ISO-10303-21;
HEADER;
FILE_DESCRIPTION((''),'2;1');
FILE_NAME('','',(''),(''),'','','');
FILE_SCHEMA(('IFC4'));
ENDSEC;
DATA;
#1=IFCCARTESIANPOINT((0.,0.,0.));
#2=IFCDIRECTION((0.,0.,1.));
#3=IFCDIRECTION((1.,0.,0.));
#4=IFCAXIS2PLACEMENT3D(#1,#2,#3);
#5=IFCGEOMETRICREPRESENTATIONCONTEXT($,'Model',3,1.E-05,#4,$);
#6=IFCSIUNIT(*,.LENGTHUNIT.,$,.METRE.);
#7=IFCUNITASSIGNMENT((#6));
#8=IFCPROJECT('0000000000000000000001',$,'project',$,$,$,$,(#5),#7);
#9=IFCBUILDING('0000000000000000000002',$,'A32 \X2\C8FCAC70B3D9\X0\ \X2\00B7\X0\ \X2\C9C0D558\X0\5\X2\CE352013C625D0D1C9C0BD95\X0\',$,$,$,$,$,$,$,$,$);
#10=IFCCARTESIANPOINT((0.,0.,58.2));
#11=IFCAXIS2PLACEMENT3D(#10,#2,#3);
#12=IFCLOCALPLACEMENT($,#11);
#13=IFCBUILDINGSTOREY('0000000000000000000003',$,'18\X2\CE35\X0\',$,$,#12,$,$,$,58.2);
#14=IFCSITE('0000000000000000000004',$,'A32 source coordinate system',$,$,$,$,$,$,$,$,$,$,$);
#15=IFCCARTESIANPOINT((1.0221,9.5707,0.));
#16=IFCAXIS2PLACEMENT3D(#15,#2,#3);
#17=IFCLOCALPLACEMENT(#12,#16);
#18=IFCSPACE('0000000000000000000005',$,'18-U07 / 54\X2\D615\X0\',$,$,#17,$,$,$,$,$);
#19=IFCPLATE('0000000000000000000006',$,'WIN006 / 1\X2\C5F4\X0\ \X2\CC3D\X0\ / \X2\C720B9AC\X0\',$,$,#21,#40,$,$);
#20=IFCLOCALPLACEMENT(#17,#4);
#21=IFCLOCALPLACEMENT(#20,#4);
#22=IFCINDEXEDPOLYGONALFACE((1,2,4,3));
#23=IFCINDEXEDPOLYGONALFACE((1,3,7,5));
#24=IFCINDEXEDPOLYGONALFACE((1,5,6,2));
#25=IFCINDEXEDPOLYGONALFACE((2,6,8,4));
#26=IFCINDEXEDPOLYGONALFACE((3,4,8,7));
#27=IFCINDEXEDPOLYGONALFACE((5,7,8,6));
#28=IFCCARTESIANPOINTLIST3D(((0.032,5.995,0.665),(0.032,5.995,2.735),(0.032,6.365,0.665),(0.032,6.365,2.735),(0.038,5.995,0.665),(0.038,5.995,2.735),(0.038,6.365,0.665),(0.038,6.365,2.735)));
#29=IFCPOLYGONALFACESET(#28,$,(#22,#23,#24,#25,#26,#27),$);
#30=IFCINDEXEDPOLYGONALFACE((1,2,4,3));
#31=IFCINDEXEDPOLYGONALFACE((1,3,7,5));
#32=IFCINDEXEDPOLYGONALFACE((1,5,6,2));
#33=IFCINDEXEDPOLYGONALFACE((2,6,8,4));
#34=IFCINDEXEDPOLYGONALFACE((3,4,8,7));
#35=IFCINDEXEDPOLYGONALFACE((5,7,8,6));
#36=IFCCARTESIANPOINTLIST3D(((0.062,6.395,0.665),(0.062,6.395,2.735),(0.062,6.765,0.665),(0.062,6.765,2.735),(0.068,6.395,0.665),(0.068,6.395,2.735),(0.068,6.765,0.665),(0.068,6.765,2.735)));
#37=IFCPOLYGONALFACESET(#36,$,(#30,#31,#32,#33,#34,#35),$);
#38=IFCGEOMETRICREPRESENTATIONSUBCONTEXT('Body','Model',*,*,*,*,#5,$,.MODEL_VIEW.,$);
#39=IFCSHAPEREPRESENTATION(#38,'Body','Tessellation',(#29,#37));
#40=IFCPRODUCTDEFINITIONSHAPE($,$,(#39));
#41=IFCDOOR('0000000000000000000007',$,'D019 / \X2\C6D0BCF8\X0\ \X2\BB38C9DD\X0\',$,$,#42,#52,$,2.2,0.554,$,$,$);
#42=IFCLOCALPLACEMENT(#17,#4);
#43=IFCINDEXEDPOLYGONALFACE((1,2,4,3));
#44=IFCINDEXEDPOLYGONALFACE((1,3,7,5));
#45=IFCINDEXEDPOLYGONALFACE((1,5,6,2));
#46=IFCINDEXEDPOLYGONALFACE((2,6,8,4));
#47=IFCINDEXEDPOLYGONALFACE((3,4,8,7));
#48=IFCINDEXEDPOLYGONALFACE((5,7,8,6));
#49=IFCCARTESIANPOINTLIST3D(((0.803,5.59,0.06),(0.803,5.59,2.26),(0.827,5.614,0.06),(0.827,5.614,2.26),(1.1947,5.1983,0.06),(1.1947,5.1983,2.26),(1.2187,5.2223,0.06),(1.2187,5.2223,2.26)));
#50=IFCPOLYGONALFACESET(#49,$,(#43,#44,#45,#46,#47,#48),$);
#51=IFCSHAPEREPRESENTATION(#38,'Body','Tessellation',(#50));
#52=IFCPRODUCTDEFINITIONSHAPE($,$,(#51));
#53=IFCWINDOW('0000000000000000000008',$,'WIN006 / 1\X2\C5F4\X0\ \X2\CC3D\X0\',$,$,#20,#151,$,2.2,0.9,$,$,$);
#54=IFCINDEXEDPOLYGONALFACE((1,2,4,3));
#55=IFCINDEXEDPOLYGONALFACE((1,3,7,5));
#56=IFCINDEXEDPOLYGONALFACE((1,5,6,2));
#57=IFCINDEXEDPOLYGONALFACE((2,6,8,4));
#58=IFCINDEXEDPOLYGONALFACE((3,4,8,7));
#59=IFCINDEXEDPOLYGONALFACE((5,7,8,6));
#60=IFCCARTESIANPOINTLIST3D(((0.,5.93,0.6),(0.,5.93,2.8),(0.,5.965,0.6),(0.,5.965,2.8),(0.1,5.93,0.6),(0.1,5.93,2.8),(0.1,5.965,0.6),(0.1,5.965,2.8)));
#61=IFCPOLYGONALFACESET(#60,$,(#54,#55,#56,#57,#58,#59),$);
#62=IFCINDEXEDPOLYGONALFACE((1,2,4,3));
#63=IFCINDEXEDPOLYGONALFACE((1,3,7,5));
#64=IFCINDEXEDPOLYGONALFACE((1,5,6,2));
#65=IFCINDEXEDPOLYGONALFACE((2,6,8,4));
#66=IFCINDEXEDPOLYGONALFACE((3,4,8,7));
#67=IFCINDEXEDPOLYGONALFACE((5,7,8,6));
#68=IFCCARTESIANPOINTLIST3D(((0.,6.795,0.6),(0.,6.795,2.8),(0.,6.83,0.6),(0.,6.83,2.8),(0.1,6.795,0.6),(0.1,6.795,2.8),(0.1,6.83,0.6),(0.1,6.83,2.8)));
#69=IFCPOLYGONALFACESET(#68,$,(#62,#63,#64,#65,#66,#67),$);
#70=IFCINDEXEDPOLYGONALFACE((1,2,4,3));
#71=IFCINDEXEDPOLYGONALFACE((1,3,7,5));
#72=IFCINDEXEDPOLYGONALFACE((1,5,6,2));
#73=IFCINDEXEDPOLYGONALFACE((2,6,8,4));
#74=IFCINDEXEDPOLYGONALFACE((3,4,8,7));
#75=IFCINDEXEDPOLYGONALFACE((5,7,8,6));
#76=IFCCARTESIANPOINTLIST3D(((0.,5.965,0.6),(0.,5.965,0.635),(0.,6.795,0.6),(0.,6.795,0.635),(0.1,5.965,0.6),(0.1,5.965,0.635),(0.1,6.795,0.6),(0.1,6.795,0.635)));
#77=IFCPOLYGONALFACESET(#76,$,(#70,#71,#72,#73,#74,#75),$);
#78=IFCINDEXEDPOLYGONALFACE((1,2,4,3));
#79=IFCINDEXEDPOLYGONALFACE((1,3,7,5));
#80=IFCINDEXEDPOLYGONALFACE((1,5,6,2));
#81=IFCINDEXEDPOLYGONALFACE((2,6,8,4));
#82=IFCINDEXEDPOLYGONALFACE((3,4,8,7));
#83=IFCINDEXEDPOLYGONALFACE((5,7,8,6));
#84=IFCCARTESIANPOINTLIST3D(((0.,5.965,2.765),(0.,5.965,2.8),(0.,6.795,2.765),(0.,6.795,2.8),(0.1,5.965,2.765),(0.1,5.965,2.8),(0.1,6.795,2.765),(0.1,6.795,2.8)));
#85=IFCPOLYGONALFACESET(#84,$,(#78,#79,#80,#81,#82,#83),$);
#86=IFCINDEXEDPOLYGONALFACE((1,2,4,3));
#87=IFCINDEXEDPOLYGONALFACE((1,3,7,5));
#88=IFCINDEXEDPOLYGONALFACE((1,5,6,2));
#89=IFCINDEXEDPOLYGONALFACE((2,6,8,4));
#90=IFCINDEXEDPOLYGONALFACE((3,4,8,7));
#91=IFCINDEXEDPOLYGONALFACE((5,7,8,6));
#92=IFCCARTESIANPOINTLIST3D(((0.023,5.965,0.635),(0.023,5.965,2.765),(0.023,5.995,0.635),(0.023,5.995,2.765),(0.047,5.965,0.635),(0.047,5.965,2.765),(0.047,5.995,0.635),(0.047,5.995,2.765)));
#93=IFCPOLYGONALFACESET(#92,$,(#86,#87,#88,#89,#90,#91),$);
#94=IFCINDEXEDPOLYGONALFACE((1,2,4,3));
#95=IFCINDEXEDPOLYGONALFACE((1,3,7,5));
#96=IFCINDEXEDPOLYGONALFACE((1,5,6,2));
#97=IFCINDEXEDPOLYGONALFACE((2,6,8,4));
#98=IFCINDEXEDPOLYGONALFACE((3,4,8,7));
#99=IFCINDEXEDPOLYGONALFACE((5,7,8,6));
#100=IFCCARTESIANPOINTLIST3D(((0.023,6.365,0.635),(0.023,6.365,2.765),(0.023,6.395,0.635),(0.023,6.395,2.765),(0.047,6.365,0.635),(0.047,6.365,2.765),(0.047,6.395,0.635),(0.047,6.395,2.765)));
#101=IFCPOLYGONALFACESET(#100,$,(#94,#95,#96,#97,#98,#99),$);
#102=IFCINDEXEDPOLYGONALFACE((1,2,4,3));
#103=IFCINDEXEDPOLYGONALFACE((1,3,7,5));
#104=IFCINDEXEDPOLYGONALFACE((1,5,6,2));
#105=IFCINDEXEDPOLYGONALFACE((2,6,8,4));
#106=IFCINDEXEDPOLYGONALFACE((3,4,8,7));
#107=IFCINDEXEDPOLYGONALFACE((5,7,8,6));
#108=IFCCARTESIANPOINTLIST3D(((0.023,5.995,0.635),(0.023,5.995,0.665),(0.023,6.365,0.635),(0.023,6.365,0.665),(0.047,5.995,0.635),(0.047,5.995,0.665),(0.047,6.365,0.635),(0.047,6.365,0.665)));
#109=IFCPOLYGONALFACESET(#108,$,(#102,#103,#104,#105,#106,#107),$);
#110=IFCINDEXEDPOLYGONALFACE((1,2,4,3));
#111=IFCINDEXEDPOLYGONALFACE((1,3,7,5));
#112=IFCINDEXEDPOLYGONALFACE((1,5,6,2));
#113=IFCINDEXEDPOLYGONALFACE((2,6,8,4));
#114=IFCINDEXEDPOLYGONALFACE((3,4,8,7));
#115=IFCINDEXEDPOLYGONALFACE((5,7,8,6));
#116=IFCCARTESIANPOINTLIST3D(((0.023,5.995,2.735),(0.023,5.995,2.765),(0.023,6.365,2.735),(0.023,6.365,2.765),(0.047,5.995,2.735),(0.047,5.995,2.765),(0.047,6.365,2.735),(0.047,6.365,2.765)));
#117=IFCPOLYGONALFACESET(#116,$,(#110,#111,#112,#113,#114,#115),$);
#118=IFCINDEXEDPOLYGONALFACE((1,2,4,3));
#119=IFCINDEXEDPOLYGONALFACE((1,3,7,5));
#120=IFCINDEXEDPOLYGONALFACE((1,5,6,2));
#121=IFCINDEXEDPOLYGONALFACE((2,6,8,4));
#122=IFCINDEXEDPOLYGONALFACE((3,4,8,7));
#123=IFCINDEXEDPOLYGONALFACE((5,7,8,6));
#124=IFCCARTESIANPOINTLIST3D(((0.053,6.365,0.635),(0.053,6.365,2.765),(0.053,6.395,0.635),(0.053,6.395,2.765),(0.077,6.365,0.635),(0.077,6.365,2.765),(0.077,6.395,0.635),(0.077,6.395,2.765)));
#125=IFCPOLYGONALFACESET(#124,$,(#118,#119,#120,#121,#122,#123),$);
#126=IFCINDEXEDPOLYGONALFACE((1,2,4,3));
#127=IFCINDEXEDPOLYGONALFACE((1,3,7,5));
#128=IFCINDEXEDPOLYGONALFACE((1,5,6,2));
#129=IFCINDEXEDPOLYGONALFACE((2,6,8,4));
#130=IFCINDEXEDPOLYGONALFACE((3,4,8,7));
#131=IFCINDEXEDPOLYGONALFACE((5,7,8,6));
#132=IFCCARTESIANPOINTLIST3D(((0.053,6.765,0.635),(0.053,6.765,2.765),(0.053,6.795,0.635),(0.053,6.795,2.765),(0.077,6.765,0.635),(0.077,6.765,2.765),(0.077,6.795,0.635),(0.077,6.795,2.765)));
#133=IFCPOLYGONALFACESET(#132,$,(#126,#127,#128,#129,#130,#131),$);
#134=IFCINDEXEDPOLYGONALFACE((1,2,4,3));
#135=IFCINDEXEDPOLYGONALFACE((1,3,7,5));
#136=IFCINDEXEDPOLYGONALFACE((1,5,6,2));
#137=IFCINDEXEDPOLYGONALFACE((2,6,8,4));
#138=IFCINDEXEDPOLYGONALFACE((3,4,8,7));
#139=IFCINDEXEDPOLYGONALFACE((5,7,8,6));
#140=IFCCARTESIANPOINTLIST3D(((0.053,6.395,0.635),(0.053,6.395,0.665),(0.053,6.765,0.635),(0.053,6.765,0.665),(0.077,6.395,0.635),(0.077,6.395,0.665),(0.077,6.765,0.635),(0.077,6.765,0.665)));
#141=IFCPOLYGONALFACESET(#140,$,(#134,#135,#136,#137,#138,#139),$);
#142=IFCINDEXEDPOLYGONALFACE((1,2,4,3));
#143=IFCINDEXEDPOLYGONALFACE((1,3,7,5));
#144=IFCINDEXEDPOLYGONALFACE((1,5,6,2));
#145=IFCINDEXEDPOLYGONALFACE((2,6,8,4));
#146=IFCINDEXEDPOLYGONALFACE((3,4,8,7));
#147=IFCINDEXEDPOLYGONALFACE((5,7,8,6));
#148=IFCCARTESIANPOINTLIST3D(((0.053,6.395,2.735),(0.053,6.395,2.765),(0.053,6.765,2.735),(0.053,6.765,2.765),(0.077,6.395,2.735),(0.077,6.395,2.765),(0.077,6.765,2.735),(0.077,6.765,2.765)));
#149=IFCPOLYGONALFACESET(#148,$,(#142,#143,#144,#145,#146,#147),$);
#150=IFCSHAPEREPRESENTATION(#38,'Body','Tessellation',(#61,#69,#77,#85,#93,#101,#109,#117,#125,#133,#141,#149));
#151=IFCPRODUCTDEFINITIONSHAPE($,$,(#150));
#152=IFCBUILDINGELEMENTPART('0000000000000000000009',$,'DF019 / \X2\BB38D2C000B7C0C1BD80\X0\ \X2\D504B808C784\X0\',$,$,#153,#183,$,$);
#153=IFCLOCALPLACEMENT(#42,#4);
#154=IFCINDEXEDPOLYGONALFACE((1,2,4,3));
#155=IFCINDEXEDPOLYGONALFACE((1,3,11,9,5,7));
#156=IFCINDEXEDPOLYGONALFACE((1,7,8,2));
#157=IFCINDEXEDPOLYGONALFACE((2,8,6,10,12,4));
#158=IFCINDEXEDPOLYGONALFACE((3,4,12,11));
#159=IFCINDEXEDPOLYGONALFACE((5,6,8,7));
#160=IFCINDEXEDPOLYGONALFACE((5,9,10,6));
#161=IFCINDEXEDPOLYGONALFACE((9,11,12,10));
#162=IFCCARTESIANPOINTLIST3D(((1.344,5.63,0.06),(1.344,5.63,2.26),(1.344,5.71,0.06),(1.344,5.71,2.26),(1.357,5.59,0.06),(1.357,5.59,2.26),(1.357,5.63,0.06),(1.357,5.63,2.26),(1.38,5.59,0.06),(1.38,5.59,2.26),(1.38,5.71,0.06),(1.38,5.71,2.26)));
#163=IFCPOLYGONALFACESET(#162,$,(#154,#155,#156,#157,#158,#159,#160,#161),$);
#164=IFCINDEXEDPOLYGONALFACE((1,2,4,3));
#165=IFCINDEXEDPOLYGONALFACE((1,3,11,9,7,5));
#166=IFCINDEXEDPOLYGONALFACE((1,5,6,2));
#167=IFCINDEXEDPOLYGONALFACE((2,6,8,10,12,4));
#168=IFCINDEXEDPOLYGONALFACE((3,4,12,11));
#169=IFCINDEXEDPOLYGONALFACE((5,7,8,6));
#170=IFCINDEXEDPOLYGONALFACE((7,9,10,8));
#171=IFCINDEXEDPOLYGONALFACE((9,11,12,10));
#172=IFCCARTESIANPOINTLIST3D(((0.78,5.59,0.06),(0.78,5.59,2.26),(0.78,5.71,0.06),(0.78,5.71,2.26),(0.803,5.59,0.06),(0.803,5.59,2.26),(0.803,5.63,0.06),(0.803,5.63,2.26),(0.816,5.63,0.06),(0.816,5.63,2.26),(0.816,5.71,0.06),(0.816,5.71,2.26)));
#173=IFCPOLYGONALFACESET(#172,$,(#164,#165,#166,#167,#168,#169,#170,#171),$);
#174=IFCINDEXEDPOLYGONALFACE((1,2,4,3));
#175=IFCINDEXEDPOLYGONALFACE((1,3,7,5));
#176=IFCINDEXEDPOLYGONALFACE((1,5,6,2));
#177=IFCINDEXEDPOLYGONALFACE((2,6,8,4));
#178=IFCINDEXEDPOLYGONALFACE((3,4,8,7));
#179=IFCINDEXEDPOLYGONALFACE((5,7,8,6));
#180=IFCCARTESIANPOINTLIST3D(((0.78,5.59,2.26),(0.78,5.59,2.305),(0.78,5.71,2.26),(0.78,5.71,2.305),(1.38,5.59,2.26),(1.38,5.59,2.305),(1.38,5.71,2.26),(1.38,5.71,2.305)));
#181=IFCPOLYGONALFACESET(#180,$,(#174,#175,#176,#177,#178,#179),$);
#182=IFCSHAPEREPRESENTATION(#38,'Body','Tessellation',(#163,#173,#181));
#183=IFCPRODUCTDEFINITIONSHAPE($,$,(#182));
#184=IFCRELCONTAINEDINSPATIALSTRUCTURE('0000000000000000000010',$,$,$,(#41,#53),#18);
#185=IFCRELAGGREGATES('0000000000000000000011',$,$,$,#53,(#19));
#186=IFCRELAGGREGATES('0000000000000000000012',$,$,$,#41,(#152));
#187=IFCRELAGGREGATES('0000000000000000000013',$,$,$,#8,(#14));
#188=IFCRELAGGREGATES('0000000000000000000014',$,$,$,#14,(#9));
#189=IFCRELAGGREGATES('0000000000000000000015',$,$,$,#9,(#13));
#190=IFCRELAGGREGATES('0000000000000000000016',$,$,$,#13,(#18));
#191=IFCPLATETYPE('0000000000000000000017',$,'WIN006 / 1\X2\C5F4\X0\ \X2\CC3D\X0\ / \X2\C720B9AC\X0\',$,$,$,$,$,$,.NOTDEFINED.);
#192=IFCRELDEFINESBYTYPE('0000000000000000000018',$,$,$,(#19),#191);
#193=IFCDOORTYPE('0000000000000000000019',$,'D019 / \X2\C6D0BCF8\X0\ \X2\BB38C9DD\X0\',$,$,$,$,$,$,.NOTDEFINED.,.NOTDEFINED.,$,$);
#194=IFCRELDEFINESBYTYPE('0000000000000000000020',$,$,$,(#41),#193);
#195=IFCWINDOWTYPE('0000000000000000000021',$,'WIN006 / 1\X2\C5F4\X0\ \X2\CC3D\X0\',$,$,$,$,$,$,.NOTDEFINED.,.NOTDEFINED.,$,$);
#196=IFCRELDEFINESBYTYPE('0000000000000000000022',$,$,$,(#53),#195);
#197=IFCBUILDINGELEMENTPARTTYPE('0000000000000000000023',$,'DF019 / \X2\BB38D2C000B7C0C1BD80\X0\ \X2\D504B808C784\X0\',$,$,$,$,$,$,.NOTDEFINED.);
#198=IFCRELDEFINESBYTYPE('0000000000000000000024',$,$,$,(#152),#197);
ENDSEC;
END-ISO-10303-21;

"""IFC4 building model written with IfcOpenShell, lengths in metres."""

from ifc_helpers import new_model, si_unit, frame, origin, origin_with_axes, place, context, subcontext, project, spatial, polyline, outline, extrude, source, transform, mapped, type_object, type_shapes, element, aggregate, save


model = new_model("IFC4")

# Units and contexts
model_context = context("Model", 3, precision=1e-05, world=origin_with_axes())
body_context = subcontext(model_context, "Body", "Model", "MODEL_VIEW")
ifc_project = project(units=[si_unit("LENGTHUNIT", "METRE")], contexts=[model_context])

# Plate
storey_placement = place(None, frame((0.0, 0.0, 58.2), z_axis=(0.0, 0.0, 1.0), x_axis=(1.0, 0.0, 0.0)))
space_placement = place(storey_placement, frame((1.0221, 9.5707, 0.0), z_axis=(0.0, 0.0, 1.0), x_axis=(1.0, 0.0, 0.0)))
plate_type_1 = type_object("IfcPlateType", Name="WIN006 / 1열 창 / 유리", PredefinedType="NOTDEFINED")
shared_shape_1 = source(origin(), body_context, "Body", "SweptSolid", [
    extrude(outline(polyline([(0.032, 5.995), (0.032, 6.365), (0.038, 6.365), (0.038, 5.995), (0.032, 5.995)])), frame((0.0, 0.0, 0.665)), (0.0, 0.0, 1.0), 2.07),
    extrude(outline(polyline([(0.062, 6.395), (0.062, 6.765), (0.068, 6.765), (0.068, 6.395), (0.062, 6.395)])), frame((0.0, 0.0, 0.665)), (0.0, 0.0, 1.0), 2.07),
])
type_shapes(plate_type_1, [shared_shape_1])
window_1_placement = place(space_placement, origin_with_axes())
plate_1_placement = place(window_1_placement, origin_with_axes())
plate_1 = element("IfcPlate", 1, at=plate_1_placement, type_object=plate_type_1, Name="WIN006 / 1열 창 / 유리", context=body_context, shape_type="MappedRepresentation", body=[
    mapped(shared_shape_1, transform((0.0, 0.0, 0.0), scale=1.0)),
])

# Site, building, storey, space
site = spatial("IfcSite", under=ifc_project, Name="A32 source coordinate system")
building = spatial("IfcBuilding", under=site, Name="A32 주거동 · 지하5층–옥탑지붕")
storey = spatial("IfcBuildingStorey", under=building, at=storey_placement, Name="18층", Elevation=58.2)
space = spatial("IfcSpace", under=storey, at=space_placement, Name="18-U07 / 54형")

# Door
door_type_1 = type_object("IfcDoorType", Name="D019 / 원본 문짝", OperationType="NOTDEFINED", PredefinedType="NOTDEFINED")
shared_shape_2 = source(origin(), body_context, "Body", "SweptSolid", [
    extrude(outline(polyline([(1.2187, 5.2223), (1.1947, 5.1983), (0.803, 5.59), (0.827, 5.614), (1.2187, 5.2223)])), frame((0.0, 0.0, 0.06)), (0.0, 0.0, 1.0), 2.2),
])
type_shapes(door_type_1, [shared_shape_2])
door_1_placement = place(space_placement, origin_with_axes())
door_1 = element("IfcDoor", 2, at=door_1_placement, inside=space, type_object=door_type_1, Name="D019 / 원본 문짝", OverallHeight=2.2, OverallWidth=0.554, context=body_context, shape_type="MappedRepresentation", body=[
    mapped(shared_shape_2, transform((0.0, 0.0, 0.0), scale=1.0)),
])

# Window
window_type_1 = type_object("IfcWindowType", Name="WIN006 / 1열 창", PartitioningType="NOTDEFINED", PredefinedType="NOTDEFINED")
shared_shape_3 = source(origin(), body_context, "Body", "SweptSolid", [
    extrude(outline(polyline([(0.0, 5.93), (0.0, 5.965), (0.1, 5.965), (0.1, 5.93), (0.0, 5.93)])), frame((0.0, 0.0, 0.6)), (0.0, 0.0, 1.0), 2.2),
    extrude(outline(polyline([(0.0, 6.795), (0.0, 6.83), (0.1, 6.83), (0.1, 6.795), (0.0, 6.795)])), frame((0.0, 0.0, 0.6)), (0.0, 0.0, 1.0), 2.2),
    extrude(outline(polyline([(0.0, 5.965), (0.0, 6.795), (0.1, 6.795), (0.1, 5.965), (0.0, 5.965)])), frame((0.0, 0.0, 0.6)), (0.0, 0.0, 1.0), 0.035),
    extrude(outline(polyline([(0.0, 5.965), (0.0, 6.795), (0.1, 6.795), (0.1, 5.965), (0.0, 5.965)])), frame((0.0, 0.0, 2.765)), (0.0, 0.0, 1.0), 0.035),
    extrude(outline(polyline([(0.023, 5.965), (0.023, 5.995), (0.047, 5.995), (0.047, 5.965), (0.023, 5.965)])), frame((0.0, 0.0, 0.635)), (0.0, 0.0, 1.0), 2.13),
    extrude(outline(polyline([(0.023, 6.365), (0.023, 6.395), (0.047, 6.395), (0.047, 6.365), (0.023, 6.365)])), frame((0.0, 0.0, 0.635)), (0.0, 0.0, 1.0), 2.13),
    extrude(outline(polyline([(0.023, 5.995), (0.023, 6.365), (0.047, 6.365), (0.047, 5.995), (0.023, 5.995)])), frame((0.0, 0.0, 0.635)), (0.0, 0.0, 1.0), 0.03),
    extrude(outline(polyline([(0.023, 5.995), (0.023, 6.365), (0.047, 6.365), (0.047, 5.995), (0.023, 5.995)])), frame((0.0, 0.0, 2.735)), (0.0, 0.0, 1.0), 0.03),
    extrude(outline(polyline([(0.053, 6.365), (0.053, 6.395), (0.077, 6.395), (0.077, 6.365), (0.053, 6.365)])), frame((0.0, 0.0, 0.635)), (0.0, 0.0, 1.0), 2.13),
    extrude(outline(polyline([(0.053, 6.765), (0.053, 6.795), (0.077, 6.795), (0.077, 6.765), (0.053, 6.765)])), frame((0.0, 0.0, 0.635)), (0.0, 0.0, 1.0), 2.13),
    extrude(outline(polyline([(0.053, 6.395), (0.053, 6.765), (0.077, 6.765), (0.077, 6.395), (0.053, 6.395)])), frame((0.0, 0.0, 0.635)), (0.0, 0.0, 1.0), 0.03),
    extrude(outline(polyline([(0.053, 6.395), (0.053, 6.765), (0.077, 6.765), (0.077, 6.395), (0.053, 6.395)])), frame((0.0, 0.0, 2.735)), (0.0, 0.0, 1.0), 0.03),
])
type_shapes(window_type_1, [shared_shape_3])
window_1 = element("IfcWindow", 3, at=window_1_placement, inside=space, type_object=window_type_1, Name="WIN006 / 1열 창", OverallHeight=2.2, OverallWidth=0.9, context=body_context, shape_type="MappedRepresentation", body=[
    mapped(shared_shape_3, transform((0.0, 0.0, 0.0), scale=1.0)),
])
aggregate(window_1, [plate_1])

# Building element part
building_element_part_type_1 = type_object("IfcBuildingElementPartType", Name="DF019 / 문틀·상부 프레임", PredefinedType="NOTDEFINED")
shared_shape_4 = source(origin(), body_context, "Body", "SweptSolid", [
    extrude(outline(polyline([(1.38, 5.59), (1.357, 5.59), (1.357, 5.63), (1.344, 5.63), (1.344, 5.71), (1.38, 5.71), (1.38, 5.59)])), frame((0.0, 0.0, 0.06)), (0.0, 0.0, 1.0), 2.2),
    extrude(outline(polyline([(0.816, 5.71), (0.816, 5.63), (0.803, 5.63), (0.803, 5.59), (0.78, 5.59), (0.78, 5.71), (0.816, 5.71)])), frame((0.0, 0.0, 0.06)), (0.0, 0.0, 1.0), 2.2),
    extrude(outline(polyline([(0.78, 5.59), (0.78, 5.71), (1.38, 5.71), (1.38, 5.59), (0.78, 5.59)])), frame((0.0, 0.0, 2.26)), (0.0, 0.0, 1.0), 0.045),
])
type_shapes(building_element_part_type_1, [shared_shape_4])
building_element_part_1_placement = place(door_1_placement, origin_with_axes())
building_element_part_1 = element("IfcBuildingElementPart", 4, at=building_element_part_1_placement, type_object=building_element_part_type_1, Name="DF019 / 문틀·상부 프레임", context=body_context, shape_type="MappedRepresentation", body=[
    mapped(shared_shape_4, transform((0.0, 0.0, 0.0), scale=1.0)),
])
aggregate(door_1, [building_element_part_1])

save(model, "model.ifc")
